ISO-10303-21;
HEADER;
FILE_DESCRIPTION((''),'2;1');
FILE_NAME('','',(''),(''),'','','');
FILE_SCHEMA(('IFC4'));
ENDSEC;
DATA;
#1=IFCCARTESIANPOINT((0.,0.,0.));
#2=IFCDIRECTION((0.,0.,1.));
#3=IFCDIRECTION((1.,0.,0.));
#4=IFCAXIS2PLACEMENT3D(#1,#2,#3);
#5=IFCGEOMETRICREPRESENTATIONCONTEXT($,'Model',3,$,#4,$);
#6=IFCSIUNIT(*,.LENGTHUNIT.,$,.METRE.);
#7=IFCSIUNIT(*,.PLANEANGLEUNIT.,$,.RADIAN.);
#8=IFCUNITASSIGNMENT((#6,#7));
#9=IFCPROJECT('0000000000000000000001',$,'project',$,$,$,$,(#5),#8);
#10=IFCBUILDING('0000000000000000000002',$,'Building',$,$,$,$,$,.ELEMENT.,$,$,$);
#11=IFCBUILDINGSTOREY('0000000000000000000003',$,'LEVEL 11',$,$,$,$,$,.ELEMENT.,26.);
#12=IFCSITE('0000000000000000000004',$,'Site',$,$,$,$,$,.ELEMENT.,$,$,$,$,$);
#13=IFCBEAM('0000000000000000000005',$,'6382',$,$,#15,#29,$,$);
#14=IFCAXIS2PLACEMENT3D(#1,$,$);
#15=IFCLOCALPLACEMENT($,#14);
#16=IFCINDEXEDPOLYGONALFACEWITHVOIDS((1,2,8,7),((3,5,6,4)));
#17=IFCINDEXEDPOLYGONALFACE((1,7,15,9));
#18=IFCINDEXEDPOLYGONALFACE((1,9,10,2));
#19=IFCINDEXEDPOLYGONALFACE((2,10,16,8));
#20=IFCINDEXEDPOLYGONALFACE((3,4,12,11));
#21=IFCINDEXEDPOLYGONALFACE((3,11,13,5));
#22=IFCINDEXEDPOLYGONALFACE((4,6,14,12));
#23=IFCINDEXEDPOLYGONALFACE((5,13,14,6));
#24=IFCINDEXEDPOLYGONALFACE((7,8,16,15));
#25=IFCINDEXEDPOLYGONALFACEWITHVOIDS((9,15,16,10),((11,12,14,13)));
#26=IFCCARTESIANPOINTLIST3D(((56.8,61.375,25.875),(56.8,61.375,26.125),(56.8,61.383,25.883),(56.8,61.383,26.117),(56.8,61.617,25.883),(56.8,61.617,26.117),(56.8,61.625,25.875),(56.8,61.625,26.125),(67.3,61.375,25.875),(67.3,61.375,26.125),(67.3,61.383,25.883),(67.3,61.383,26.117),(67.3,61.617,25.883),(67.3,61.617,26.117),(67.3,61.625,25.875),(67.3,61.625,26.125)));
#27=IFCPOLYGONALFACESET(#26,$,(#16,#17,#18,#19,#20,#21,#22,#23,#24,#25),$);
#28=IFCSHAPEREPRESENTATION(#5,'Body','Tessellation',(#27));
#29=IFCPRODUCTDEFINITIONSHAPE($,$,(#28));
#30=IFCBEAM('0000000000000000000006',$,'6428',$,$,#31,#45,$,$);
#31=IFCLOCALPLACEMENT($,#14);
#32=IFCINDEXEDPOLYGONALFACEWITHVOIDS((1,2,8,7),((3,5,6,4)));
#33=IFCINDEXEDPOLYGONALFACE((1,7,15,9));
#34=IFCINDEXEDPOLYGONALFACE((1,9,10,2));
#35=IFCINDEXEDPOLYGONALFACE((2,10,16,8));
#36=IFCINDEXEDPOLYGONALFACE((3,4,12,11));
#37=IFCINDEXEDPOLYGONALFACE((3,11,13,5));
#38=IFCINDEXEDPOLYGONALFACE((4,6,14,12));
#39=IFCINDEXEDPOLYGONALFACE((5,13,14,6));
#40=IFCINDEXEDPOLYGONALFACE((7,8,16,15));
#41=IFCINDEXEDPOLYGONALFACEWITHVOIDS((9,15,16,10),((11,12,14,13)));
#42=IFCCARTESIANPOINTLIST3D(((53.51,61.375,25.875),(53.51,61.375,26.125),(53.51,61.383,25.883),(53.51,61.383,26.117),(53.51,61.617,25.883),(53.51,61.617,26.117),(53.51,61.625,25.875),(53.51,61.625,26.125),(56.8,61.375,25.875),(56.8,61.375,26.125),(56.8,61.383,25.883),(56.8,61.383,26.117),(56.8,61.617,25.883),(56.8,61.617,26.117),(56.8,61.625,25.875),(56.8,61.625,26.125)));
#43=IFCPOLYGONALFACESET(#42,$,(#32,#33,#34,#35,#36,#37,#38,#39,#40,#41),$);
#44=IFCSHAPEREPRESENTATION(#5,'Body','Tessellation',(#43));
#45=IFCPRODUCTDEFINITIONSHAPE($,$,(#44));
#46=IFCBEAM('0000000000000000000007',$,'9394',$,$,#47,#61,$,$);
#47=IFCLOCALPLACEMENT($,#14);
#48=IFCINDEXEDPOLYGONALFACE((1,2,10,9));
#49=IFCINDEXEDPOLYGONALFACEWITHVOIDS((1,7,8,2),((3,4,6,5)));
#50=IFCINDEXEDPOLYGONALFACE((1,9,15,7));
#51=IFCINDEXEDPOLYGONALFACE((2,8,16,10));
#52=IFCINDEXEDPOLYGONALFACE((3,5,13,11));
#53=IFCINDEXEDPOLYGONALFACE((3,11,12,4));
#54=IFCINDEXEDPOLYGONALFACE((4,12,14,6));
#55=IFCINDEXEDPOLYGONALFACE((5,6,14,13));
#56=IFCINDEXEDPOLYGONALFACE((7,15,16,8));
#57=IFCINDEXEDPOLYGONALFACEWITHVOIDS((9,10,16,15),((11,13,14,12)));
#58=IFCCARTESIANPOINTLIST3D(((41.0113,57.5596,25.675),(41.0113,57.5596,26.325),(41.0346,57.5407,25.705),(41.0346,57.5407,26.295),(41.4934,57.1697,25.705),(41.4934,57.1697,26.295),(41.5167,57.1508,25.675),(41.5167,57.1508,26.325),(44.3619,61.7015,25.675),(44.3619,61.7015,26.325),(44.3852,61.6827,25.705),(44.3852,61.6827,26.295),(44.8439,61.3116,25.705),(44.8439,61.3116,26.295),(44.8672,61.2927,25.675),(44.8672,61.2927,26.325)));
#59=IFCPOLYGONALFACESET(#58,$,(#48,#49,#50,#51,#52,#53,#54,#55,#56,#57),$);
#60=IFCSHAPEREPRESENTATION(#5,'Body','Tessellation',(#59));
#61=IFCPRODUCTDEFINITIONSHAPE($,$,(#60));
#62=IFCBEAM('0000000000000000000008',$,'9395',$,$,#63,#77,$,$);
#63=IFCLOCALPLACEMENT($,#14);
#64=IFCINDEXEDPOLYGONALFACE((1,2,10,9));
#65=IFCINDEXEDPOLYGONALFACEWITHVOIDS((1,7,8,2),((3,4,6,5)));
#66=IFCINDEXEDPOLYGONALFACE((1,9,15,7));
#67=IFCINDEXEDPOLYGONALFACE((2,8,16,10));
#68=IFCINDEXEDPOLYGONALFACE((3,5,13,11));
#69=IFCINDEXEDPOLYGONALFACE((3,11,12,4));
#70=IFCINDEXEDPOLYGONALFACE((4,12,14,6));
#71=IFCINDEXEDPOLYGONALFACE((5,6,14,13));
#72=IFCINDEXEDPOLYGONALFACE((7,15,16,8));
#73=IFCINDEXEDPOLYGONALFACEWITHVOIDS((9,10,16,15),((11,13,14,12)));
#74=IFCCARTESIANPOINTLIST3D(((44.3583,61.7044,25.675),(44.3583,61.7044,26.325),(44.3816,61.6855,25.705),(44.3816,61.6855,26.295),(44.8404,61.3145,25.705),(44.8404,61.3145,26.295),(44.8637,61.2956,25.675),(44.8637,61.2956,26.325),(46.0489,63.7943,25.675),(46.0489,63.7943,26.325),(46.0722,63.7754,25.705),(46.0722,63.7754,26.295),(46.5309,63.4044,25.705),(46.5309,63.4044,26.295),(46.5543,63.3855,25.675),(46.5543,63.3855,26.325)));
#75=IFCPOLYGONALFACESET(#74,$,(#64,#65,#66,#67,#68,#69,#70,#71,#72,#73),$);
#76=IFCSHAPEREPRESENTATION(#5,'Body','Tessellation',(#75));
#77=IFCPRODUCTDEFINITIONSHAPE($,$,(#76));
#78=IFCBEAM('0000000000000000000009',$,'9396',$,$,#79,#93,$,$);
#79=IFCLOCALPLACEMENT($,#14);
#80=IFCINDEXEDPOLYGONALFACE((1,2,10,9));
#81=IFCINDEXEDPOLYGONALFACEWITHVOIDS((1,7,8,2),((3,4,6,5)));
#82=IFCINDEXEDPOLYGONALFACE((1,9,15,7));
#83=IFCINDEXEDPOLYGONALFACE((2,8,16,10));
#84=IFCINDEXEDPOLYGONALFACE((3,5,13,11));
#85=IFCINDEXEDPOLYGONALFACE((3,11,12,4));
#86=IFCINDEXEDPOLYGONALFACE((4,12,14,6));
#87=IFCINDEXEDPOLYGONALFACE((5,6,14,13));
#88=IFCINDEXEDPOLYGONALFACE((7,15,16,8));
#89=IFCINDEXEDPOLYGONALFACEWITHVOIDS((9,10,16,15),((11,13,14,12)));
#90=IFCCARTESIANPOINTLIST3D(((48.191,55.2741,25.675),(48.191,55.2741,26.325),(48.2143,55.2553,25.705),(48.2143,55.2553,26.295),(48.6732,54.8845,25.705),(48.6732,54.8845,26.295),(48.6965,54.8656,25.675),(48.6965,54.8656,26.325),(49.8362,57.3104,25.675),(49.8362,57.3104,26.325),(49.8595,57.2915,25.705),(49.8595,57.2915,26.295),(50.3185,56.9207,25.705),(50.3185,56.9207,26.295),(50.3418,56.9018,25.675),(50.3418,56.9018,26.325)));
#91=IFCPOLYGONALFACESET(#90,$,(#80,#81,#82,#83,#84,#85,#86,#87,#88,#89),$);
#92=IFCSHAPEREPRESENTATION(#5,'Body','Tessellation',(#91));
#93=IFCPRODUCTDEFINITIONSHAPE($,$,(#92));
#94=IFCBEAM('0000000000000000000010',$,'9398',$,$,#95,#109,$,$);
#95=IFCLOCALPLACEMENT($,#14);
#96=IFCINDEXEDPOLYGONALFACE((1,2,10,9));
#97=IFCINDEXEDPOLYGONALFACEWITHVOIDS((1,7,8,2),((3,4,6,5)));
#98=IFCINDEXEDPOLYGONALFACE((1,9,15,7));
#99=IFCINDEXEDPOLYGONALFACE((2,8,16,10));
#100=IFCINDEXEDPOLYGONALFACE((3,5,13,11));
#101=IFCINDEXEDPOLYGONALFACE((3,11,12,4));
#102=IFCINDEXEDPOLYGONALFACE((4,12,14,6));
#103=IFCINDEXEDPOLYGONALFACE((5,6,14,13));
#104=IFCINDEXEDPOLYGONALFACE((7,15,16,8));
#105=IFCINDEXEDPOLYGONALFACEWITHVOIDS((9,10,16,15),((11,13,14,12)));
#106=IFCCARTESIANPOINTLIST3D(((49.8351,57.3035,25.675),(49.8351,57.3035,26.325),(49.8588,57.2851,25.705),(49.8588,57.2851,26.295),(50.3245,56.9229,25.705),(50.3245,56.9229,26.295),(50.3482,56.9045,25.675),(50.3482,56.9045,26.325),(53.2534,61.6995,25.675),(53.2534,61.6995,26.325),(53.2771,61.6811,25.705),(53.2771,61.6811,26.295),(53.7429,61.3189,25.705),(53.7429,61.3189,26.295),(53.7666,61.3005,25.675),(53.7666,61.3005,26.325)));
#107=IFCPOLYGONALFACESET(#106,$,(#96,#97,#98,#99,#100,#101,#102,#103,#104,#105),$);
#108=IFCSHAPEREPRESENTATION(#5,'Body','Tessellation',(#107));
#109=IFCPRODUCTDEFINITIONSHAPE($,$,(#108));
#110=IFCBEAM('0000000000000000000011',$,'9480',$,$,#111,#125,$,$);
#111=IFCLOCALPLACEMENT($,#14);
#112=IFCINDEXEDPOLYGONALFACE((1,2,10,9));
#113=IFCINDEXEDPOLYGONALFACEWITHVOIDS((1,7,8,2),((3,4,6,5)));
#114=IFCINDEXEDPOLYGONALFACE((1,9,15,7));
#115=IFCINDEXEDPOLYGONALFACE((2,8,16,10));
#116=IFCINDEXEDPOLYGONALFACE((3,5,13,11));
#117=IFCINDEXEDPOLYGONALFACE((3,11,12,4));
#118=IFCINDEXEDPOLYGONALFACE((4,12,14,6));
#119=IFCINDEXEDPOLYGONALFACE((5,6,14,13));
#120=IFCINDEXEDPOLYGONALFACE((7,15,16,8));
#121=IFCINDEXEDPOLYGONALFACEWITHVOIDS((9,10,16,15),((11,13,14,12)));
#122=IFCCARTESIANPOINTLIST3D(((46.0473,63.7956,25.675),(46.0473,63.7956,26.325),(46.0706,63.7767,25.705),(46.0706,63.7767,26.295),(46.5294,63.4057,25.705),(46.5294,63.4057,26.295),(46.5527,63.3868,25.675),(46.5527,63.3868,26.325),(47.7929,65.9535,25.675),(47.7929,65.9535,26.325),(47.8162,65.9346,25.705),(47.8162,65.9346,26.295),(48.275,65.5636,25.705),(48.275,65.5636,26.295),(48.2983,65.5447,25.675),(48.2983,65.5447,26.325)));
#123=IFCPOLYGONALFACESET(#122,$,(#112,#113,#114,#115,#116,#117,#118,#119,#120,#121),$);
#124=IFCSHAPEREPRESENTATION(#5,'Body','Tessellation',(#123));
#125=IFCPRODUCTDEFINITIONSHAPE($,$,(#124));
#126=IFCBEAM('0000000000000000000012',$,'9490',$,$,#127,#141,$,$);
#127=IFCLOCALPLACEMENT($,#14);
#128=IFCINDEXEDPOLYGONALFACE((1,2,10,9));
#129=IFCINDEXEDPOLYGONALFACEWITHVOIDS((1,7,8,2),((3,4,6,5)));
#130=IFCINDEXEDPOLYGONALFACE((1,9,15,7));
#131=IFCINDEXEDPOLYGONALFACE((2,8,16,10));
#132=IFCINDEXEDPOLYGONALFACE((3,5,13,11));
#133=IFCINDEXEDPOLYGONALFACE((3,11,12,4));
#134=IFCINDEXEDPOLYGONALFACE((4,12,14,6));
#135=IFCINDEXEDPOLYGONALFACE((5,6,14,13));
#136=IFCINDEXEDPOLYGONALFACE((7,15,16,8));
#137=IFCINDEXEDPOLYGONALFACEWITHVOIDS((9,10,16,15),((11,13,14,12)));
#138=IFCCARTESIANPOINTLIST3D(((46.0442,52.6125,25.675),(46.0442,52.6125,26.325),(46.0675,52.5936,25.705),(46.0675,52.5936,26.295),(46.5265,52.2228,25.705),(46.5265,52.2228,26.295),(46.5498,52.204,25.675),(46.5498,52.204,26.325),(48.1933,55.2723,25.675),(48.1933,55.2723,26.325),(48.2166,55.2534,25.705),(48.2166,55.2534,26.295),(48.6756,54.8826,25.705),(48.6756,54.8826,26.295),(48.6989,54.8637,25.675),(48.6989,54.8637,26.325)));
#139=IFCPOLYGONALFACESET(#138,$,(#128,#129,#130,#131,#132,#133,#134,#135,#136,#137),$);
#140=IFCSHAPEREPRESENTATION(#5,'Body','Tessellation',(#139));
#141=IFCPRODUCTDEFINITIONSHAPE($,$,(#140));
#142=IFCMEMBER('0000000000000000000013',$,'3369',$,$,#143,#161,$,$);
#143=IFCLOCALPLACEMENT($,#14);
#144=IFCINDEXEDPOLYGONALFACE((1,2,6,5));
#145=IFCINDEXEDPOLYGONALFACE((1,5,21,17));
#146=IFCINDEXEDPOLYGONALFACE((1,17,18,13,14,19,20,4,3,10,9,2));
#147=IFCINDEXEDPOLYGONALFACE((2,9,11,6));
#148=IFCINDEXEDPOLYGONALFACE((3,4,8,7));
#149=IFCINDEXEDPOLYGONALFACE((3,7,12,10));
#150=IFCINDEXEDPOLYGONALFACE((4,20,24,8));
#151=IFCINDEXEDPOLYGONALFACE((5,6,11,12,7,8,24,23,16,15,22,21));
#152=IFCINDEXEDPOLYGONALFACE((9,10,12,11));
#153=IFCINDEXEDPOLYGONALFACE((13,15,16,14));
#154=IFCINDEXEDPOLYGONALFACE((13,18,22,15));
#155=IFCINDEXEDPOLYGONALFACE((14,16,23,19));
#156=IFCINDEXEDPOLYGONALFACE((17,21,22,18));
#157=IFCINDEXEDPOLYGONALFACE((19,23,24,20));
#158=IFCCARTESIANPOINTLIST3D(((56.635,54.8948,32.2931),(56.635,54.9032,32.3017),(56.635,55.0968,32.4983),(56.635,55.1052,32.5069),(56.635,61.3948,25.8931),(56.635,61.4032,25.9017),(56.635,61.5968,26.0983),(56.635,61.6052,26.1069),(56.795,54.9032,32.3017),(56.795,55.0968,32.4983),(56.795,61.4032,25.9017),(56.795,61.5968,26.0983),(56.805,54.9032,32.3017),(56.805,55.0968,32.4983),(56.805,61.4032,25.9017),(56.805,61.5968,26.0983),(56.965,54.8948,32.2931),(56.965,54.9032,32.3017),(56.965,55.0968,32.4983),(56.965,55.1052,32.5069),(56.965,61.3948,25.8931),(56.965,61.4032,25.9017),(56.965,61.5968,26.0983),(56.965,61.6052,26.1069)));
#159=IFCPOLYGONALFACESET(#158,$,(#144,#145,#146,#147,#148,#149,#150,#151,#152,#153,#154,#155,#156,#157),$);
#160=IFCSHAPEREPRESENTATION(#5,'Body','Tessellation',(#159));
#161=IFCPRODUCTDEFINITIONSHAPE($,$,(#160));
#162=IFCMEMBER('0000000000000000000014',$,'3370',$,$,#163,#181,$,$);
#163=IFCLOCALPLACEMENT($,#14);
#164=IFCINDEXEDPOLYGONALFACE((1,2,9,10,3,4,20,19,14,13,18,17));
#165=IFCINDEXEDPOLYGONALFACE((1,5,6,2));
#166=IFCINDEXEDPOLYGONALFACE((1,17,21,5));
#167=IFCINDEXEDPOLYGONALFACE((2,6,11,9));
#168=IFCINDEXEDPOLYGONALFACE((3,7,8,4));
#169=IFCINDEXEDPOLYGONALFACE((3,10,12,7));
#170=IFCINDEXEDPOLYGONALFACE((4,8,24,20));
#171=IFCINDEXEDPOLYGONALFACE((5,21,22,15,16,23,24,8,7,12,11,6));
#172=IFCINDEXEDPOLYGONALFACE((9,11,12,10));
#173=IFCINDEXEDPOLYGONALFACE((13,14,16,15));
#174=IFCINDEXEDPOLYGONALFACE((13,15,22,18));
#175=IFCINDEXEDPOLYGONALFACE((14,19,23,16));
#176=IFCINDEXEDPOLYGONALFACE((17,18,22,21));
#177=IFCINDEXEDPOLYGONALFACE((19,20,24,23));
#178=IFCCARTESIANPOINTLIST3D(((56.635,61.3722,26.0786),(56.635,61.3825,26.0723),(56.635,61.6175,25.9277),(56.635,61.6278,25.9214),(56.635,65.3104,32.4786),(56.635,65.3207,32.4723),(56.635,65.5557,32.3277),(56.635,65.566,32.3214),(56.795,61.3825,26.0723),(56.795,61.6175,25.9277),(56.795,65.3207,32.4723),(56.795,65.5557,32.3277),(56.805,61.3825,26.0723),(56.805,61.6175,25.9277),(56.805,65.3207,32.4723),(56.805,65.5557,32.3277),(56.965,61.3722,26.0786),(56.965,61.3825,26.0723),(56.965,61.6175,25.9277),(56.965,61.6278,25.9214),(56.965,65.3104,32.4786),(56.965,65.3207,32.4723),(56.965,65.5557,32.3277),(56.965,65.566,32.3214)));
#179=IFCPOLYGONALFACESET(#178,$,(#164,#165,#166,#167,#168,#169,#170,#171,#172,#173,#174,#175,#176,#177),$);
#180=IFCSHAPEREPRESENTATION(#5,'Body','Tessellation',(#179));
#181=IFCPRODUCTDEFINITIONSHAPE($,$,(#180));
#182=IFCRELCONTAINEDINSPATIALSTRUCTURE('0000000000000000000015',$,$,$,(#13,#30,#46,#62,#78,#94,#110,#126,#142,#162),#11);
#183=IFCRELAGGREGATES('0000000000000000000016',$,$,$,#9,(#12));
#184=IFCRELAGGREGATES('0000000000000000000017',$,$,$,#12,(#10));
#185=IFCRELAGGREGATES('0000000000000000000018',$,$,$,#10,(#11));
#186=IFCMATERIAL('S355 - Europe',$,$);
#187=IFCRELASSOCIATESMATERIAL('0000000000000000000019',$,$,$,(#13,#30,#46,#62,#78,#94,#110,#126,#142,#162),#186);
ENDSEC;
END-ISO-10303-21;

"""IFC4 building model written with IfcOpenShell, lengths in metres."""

from ifc_helpers import new_model, si_unit, frame, origin_with_axes, origin_2d_with_axis, place, context, project, spatial, hollow_rectangle, i_section, extrude, material, material_profile, profile_set, profile_usage, element, save


model = new_model("IFC4")

# Units and contexts
model_context = context("Model", 3, world=origin_with_axes())
ifc_project = project(units=[si_unit("LENGTHUNIT", "METRE"), si_unit("PLANEANGLEUNIT", "RADIAN")], contexts=[model_context])

# Site, building, storey
site = spatial("IfcSite", under=ifc_project, Name="Site", CompositionType="ELEMENT")
building = spatial("IfcBuilding", under=site, Name="Building", CompositionType="ELEMENT")
storey = spatial("IfcBuildingStorey", under=building, Name="LEVEL 11", CompositionType="ELEMENT", Elevation=26.0)

# Shared definitions
ifc_material = material(Name="S355 - Europe")

# Beams
ifc_material_profile_1 = material_profile(ifc_material, hollow_rectangle(XDim=0.25, YDim=0.25, WallThickness=0.008, at=origin_2d_with_axis()))
ifc_profile_set_1 = profile_set([ifc_material_profile_1])
ifc_profile_usage_1 = profile_usage(ifc_profile_set_1, cardinal=10)
beam_1_placement = place(None, frame((56.8, 61.5, 26.0), z_axis=(1.0, 0.0, 0.0), x_axis=(0.0, 1.0, 0.0)))
element("IfcBeam", 1, at=beam_1_placement, inside=storey, material=ifc_profile_usage_1, Name="6382", context=model_context, shape_type="SweptSolid", body=[
    extrude(hollow_rectangle(XDim=0.25, YDim=0.25, WallThickness=0.008, at=origin_2d_with_axis()), origin_with_axes(), (0.0, 0.0, 1.0), 10.5),
])
ifc_material_profile_2 = material_profile(ifc_material, hollow_rectangle(XDim=0.25, YDim=0.25, WallThickness=0.008, at=origin_2d_with_axis()))
ifc_profile_set_2 = profile_set([ifc_material_profile_2])
ifc_profile_usage_2 = profile_usage(ifc_profile_set_2, cardinal=10)
beam_2_placement = place(None, frame((56.8, 61.5, 26.0), z_axis=(-1.0, 0.0, 0.0), x_axis=(0.0, -1.0, 0.0)))
element("IfcBeam", 2, at=beam_2_placement, inside=storey, material=ifc_profile_usage_2, Name="6428", context=model_context, shape_type="SweptSolid", body=[
    extrude(hollow_rectangle(XDim=0.25, YDim=0.25, WallThickness=0.008, at=origin_2d_with_axis()), origin_with_axes(), (0.0, 0.0, 1.0), 3.29),
])
ifc_material_profile_3 = material_profile(ifc_material, hollow_rectangle(XDim=0.65, YDim=0.65, WallThickness=0.03, at=origin_2d_with_axis()))
ifc_profile_set_3 = profile_set([ifc_material_profile_3])
ifc_profile_usage_3 = profile_usage(ifc_profile_set_3, cardinal=10)
beam_3_placement = place(None, frame((41.264, 57.3552, 26.0), z_axis=(0.62892, 0.77747, 0.0), x_axis=(-0.777826, 0.62848, 0.0)))
element("IfcBeam", 3, at=beam_3_placement, inside=storey, material=ifc_profile_usage_3, Name="9394", context=model_context, shape_type="SweptSolid", body=[
    extrude(hollow_rectangle(XDim=0.65, YDim=0.65, WallThickness=0.03, at=origin_2d_with_axis()), origin_with_axes(), (0.0, 0.0, 1.0), 5.3275),
])
ifc_material_profile_4 = material_profile(ifc_material, hollow_rectangle(XDim=0.65, YDim=0.65, WallThickness=0.03, at=origin_2d_with_axis()))
ifc_profile_set_4 = profile_set([ifc_material_profile_4])
ifc_profile_usage_4 = profile_usage(ifc_profile_set_4, cardinal=10)
beam_4_placement = place(None, frame((44.611, 61.5, 26.0), z_axis=(0.62892, 0.77747, 0.0), x_axis=(-0.777826, 0.62848, 0.0)))
element("IfcBeam", 4, at=beam_4_placement, inside=storey, material=ifc_profile_usage_4, Name="9395", context=model_context, shape_type="SweptSolid", body=[
    extrude(hollow_rectangle(XDim=0.65, YDim=0.65, WallThickness=0.03, at=origin_2d_with_axis()), origin_with_axes(), (0.0, 0.0, 1.0), 2.6881),
])
ifc_material_profile_5 = material_profile(ifc_material, hollow_rectangle(XDim=0.65, YDim=0.65, WallThickness=0.03, at=origin_2d_with_axis()))
ifc_profile_set_5 = profile_set([ifc_material_profile_5])
ifc_profile_usage_5 = profile_usage(ifc_profile_set_5, cardinal=10)
beam_5_placement = place(None, frame((50.089, 57.1061, 26.0), z_axis=(-0.62848, -0.777826, 0.0), x_axis=(0.77854, -0.627595, 0.0)))
element("IfcBeam", 5, at=beam_5_placement, inside=storey, material=ifc_profile_usage_5, Name="9396", context=model_context, shape_type="SweptSolid", body=[
    extrude(hollow_rectangle(XDim=0.65, YDim=0.65, WallThickness=0.03, at=origin_2d_with_axis()), origin_with_axes(), (0.0, 0.0, 1.0), 2.6178),
])
ifc_material_profile_6 = material_profile(ifc_material, hollow_rectangle(XDim=0.65, YDim=0.65, WallThickness=0.03, at=origin_2d_with_axis()))
ifc_profile_set_6 = profile_set([ifc_material_profile_6])
ifc_profile_usage_6 = profile_usage(ifc_profile_set_6, cardinal=10)
beam_6_placement = place(None, frame((53.51, 61.5, 26.0), z_axis=(-0.613857, -0.789418, 0.0), x_axis=(0.789796, -0.61337, 0.0)))
element("IfcBeam", 6, at=beam_6_placement, inside=storey, material=ifc_profile_usage_6, Name="9398", context=model_context, shape_type="SweptSolid", body=[
    extrude(hollow_rectangle(XDim=0.65, YDim=0.65, WallThickness=0.03, at=origin_2d_with_axis()), origin_with_axes(), (0.0, 0.0, 1.0), 5.5686),
])
ifc_material_profile_7 = material_profile(ifc_material, hollow_rectangle(XDim=0.65, YDim=0.65, WallThickness=0.03, at=origin_2d_with_axis()))
ifc_profile_set_7 = profile_set([ifc_material_profile_7])
ifc_profile_usage_7 = profile_usage(ifc_profile_set_7, cardinal=10)
beam_7_placement = place(None, frame((46.3, 63.5912, 26.0), z_axis=(0.62892, 0.77747, 0.0), x_axis=(-0.777826, 0.62848, 0.0)))
element("IfcBeam", 7, at=beam_7_placement, inside=storey, material=ifc_profile_usage_7, Name="9480", context=model_context, shape_type="SweptSolid", body=[
    extrude(hollow_rectangle(XDim=0.65, YDim=0.65, WallThickness=0.03, at=origin_2d_with_axis()), origin_with_axes(), (0.0, 0.0, 1.0), 2.7756),
])
ifc_material_profile_8 = material_profile(ifc_material, hollow_rectangle(XDim=0.65, YDim=0.65, WallThickness=0.03, at=origin_2d_with_axis()))
ifc_profile_set_8 = profile_set([ifc_material_profile_8])
ifc_profile_usage_8 = profile_usage(ifc_profile_set_8, cardinal=10)
beam_8_placement = place(None, frame((48.4461, 55.068, 26.0), z_axis=(-0.62848, -0.777826, 0.0), x_axis=(0.77854, -0.627595, 0.0)))
element("IfcBeam", 8, at=beam_8_placement, inside=storey, material=ifc_profile_usage_8, Name="9490", context=model_context, shape_type="SweptSolid", body=[
    extrude(hollow_rectangle(XDim=0.65, YDim=0.65, WallThickness=0.03, at=origin_2d_with_axis()), origin_with_axes(), (0.0, 0.0, 1.0), 3.4195),
])

# Members
ifc_material_profile_9 = material_profile(ifc_material, i_section(OverallWidth=0.33, OverallDepth=0.3, WebThickness=0.01, FlangeThickness=0.012, at=origin_2d_with_axis()))
ifc_profile_set_9 = profile_set([ifc_material_profile_9])
ifc_profile_usage_9 = profile_usage(ifc_profile_set_9, cardinal=10)
member_1_placement = place(None, frame((56.8, 61.5, 26.0), z_axis=(0.0, -0.712567, 0.701604), x_axis=(1.0, 0.0, 0.0)))
element("IfcMember", 9, at=member_1_placement, inside=storey, material=ifc_profile_usage_9, Name="3369", context=model_context, shape_type="SweptSolid", body=[
    extrude(i_section(OverallWidth=0.33, OverallDepth=0.3, WebThickness=0.01, FlangeThickness=0.012, at=origin_2d_with_axis()), origin_with_axes(), (0.0, 0.0, 1.0), 9.122),
])
ifc_material_profile_10 = material_profile(ifc_material, i_section(OverallWidth=0.33, OverallDepth=0.3, WebThickness=0.01, FlangeThickness=0.012, at=origin_2d_with_axis()))
ifc_profile_set_10 = profile_set([ifc_material_profile_10])
ifc_profile_usage_10 = profile_usage(ifc_profile_set_10, cardinal=10)
member_2_placement = place(None, frame((56.8, 61.5, 26.0), z_axis=(0.0, 0.524072, 0.851674), x_axis=(-1.0, 0.0, 0.0)))
element("IfcMember", 10, at=member_2_placement, inside=storey, material=ifc_profile_usage_10, Name="3370", context=model_context, shape_type="SweptSolid", body=[
    extrude(i_section(OverallWidth=0.33, OverallDepth=0.3, WebThickness=0.01, FlangeThickness=0.012, at=origin_2d_with_axis()), origin_with_axes(), (0.0, 0.0, 1.0), 7.5146),
])

save(model, "model.ifc")
